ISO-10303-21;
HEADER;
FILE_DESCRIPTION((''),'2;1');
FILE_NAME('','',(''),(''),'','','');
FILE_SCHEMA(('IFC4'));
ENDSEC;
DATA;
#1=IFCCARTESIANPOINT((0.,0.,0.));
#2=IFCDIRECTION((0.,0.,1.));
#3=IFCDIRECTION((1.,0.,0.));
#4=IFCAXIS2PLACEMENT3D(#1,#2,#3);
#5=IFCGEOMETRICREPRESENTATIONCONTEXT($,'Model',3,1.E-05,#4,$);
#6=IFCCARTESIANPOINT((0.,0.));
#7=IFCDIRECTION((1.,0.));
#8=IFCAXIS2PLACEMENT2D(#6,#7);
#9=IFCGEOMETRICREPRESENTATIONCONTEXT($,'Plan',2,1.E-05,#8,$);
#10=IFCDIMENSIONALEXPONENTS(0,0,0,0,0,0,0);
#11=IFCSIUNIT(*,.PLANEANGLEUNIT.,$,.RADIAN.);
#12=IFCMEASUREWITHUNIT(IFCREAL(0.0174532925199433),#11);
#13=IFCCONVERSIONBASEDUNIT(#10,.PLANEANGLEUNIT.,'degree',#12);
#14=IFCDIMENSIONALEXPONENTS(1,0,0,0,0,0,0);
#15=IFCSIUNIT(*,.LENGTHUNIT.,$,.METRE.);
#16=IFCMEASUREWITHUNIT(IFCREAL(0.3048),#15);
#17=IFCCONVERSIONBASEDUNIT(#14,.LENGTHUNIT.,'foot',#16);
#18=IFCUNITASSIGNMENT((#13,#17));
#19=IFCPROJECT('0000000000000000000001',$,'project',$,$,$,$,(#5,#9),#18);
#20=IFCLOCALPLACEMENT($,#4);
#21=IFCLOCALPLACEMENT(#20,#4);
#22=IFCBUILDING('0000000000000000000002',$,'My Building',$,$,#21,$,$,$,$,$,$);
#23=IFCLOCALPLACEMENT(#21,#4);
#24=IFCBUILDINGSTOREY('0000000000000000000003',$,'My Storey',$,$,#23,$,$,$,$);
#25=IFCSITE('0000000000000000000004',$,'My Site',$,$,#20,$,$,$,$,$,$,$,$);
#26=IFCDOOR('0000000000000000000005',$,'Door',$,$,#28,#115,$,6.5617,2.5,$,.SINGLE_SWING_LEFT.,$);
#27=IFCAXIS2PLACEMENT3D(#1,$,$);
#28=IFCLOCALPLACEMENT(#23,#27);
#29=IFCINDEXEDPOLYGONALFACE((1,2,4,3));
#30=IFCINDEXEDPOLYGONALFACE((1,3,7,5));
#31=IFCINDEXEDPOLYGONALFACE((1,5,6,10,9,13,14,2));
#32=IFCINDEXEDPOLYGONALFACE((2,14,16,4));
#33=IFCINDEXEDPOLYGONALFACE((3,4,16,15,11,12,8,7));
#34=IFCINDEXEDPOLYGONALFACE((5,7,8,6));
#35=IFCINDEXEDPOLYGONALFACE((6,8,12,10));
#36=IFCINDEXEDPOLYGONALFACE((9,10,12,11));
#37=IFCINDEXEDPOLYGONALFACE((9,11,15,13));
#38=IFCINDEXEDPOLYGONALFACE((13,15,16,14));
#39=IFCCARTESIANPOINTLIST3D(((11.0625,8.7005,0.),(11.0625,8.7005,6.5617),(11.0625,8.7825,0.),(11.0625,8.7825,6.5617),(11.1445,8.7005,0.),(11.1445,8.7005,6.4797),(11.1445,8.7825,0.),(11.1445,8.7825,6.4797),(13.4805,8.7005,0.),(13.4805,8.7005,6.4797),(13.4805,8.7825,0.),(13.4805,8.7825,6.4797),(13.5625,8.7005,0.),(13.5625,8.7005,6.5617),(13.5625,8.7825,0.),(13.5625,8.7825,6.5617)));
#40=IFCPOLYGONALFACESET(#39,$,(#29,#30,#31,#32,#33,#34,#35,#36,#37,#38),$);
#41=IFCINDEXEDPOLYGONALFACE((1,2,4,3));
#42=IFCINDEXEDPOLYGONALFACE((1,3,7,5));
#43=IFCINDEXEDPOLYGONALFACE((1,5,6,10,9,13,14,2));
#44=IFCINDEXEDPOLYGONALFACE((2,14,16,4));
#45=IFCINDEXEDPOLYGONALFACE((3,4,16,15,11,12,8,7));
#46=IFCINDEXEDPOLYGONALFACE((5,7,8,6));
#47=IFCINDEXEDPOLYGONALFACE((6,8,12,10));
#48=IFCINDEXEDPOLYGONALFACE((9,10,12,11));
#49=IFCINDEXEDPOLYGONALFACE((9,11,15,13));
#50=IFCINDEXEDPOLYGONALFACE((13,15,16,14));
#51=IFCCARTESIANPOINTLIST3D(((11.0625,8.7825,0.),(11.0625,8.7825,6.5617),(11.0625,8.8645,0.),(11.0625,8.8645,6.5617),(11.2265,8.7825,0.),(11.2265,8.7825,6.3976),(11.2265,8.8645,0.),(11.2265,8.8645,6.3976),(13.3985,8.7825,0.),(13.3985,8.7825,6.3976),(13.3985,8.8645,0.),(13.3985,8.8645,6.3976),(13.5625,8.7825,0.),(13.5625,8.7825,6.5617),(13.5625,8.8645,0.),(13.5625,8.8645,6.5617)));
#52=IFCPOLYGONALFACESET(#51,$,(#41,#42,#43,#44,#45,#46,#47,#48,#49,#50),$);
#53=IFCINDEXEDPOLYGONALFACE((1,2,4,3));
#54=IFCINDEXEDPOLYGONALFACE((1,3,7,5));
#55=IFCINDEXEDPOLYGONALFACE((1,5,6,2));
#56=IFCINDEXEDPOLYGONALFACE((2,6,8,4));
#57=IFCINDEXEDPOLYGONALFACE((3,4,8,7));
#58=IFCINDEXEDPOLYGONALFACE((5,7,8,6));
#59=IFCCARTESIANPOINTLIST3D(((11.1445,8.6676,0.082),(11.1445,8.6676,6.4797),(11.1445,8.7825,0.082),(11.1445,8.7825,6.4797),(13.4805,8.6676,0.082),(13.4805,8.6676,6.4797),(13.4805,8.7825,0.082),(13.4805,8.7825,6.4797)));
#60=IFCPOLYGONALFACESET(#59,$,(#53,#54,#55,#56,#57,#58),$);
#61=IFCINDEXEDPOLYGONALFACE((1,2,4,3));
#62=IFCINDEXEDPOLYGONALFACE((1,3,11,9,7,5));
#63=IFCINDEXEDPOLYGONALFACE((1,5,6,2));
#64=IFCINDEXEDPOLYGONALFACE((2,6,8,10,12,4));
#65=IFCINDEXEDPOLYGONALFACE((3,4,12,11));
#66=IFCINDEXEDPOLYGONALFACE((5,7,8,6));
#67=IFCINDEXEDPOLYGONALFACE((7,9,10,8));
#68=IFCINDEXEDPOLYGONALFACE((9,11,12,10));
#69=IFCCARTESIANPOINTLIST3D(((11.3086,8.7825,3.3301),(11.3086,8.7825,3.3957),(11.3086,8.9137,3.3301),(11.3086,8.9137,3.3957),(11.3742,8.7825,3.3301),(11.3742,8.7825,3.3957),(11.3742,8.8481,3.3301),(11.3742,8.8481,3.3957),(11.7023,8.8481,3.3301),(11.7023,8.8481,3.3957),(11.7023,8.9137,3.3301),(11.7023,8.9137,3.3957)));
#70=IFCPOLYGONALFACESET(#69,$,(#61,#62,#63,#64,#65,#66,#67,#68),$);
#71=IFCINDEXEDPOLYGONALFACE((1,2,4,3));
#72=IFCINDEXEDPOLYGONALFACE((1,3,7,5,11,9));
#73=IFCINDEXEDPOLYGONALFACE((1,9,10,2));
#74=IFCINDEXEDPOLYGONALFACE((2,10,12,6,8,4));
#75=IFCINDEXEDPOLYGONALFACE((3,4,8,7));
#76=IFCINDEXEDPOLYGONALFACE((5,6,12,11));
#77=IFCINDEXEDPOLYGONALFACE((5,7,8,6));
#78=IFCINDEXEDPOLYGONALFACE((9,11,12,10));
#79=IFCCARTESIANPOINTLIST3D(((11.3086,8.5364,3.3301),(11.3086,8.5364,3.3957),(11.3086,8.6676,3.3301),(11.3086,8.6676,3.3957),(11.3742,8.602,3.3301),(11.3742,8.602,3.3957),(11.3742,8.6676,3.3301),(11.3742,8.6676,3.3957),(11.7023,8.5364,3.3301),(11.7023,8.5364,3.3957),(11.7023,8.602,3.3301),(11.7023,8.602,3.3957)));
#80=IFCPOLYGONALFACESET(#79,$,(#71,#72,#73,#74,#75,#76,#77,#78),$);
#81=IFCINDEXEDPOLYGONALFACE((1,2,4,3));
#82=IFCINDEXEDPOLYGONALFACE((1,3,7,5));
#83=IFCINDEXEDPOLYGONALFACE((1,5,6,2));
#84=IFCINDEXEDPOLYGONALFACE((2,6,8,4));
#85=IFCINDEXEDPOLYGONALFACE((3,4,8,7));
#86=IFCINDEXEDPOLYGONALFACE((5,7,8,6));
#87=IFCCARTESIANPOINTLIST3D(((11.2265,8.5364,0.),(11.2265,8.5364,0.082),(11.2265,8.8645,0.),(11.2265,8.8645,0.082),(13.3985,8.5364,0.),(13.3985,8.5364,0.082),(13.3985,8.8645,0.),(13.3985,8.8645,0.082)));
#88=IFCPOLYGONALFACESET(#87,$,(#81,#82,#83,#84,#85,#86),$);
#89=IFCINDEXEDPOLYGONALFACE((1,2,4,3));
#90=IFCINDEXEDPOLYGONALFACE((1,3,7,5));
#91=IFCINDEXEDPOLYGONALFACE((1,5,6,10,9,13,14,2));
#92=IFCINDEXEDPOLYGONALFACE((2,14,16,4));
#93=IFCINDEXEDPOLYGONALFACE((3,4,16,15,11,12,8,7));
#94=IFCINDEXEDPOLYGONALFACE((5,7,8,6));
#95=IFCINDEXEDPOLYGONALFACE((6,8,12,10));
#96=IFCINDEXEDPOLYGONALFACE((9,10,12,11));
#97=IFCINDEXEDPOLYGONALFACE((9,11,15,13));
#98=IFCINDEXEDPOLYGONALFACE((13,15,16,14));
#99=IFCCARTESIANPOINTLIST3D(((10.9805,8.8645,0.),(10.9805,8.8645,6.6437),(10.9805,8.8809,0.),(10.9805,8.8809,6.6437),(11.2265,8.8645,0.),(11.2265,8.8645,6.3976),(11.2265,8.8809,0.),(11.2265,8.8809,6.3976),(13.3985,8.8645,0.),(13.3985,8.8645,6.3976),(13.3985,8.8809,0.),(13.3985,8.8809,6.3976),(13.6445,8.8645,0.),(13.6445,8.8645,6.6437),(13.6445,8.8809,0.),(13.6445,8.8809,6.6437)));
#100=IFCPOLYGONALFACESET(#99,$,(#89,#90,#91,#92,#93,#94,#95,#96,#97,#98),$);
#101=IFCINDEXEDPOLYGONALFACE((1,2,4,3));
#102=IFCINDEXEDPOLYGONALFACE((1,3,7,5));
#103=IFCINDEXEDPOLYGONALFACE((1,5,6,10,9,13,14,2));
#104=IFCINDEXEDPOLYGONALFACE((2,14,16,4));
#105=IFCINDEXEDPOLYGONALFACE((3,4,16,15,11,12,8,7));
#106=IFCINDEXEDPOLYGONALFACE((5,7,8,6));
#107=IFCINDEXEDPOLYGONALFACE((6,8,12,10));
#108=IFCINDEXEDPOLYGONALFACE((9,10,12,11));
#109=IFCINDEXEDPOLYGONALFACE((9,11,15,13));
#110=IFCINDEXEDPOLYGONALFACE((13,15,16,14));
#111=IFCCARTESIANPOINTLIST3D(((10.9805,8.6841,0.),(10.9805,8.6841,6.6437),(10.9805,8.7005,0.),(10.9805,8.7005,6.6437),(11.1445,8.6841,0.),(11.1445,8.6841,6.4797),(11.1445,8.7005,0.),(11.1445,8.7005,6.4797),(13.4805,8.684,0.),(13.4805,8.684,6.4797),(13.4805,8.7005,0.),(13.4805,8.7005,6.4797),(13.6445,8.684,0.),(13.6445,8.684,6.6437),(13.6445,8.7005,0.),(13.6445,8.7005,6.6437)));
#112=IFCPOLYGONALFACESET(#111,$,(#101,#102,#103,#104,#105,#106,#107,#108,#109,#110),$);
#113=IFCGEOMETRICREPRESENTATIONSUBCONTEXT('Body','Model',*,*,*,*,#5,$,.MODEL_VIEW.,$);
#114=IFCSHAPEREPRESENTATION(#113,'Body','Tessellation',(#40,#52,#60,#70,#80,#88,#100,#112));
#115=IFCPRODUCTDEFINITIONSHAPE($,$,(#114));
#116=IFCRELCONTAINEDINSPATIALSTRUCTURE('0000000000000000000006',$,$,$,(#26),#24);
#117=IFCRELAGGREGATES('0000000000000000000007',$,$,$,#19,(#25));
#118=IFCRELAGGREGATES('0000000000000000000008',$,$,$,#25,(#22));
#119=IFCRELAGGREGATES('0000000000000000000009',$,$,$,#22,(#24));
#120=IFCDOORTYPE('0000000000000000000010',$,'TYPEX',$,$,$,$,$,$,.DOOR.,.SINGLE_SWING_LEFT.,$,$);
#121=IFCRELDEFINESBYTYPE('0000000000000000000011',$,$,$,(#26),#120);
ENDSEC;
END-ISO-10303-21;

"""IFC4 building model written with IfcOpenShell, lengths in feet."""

from ifc_helpers import new_model, entity, si_unit, converted_unit, frame, origin_with_axes, origin_2d_with_axis, place, context, subcontext, project, spatial, line, indexed_curve, outline, extrude, shape, source, transform, mapped, type_object, type_shapes, element, save


model = new_model("IFC4")

# Units and contexts
model_context = context("Model", 3, precision=1e-05, world=origin_with_axes())
plan_context = context("Plan", 2, precision=1e-05, world=origin_2d_with_axis())
body_context_1 = subcontext(model_context, "Body", "Model", "MODEL_VIEW")
body_context_2 = subcontext(plan_context, "Body", "Plan", "PLAN_VIEW")
ifc_project = project(units=[converted_unit("PLANEANGLEUNIT", "degree", entity("IfcReal", 0.0174532925199433), si_unit("PLANEANGLEUNIT", "RADIAN"), dimensions=[0, 0, 0, 0, 0, 0, 0]), converted_unit("LENGTHUNIT", "foot", entity("IfcReal", 0.3048), si_unit("LENGTHUNIT", "METRE"), dimensions=[1, 0, 0, 0, 0, 0, 0])], contexts=[model_context, plan_context])

# Site, building, storey
site_placement = place(None, origin_with_axes())
site = spatial("IfcSite", under=ifc_project, at=site_placement, Name="My Site")
building_placement = place(site_placement, origin_with_axes())
building = spatial("IfcBuilding", under=site, at=building_placement, Name="My Building")
storey_placement = place(building_placement, origin_with_axes())
storey = spatial("IfcBuildingStorey", under=building, at=storey_placement, Name="My Storey")

# Door
door_type = type_object("IfcDoorType", Name="TYPEX", OperationType="SINGLE_SWING_LEFT", PredefinedType="DOOR")
shared_shape_1 = source(origin_with_axes(), body_context_1, "Body", "SweptSolid", [
    extrude(outline(indexed_curve([(0.0, 0.0), (0.0, 6.5617), (2.5, 6.5617), (2.5, 0.0), (2.418, 0.0), (2.418, 6.4797), (0.082, 6.4797), (0.082, 0.0)], segments=[line(1, 2, 3, 4, 5, 6, 7, 8, 1)])), frame((0.0, 0.082, 0.0), z_axis=(0.0, -1.0, 0.0), x_axis=(1.0, 0.0, 0.0)), (0.0, 0.0, -1.0), 0.082),
    extrude(outline(indexed_curve([(0.0, 0.0), (0.0, 6.5617), (2.5, 6.5617), (2.5, 0.0), (2.336, 0.0), (2.336, 6.3976), (0.164, 6.3976), (0.164, 0.0)], segments=[line(1, 2, 3, 4, 5, 6, 7, 8, 1)])), frame((0.0, 0.0, 0.0), z_axis=(0.0, -1.0, 0.0), x_axis=(1.0, 0.0, 0.0)), (0.0, 0.0, -1.0), 0.082),
    extrude(outline(indexed_curve([(0.0, 0.0), (2.336, 0.0), (2.336, 0.1148), (0.0, 0.1148)], segments=[line(1, 2, 3, 4, 1)])), frame((0.082, 0.082, 0.082), z_axis=(0.0, 0.0, 1.0), x_axis=(1.0, 0.0, 0.0)), (0.0, 0.0, 1.0), 6.3976),
    extrude(outline(indexed_curve([(0.0, 0.0), (0.0, -0.1312), (-0.3937, -0.1312), (-0.3937, -0.0656), (-0.0656, -0.0656), (-0.0656, 0.0)], segments=[line(1, 2, 3, 4, 5, 6, 1)])), frame((2.2539, 0.082, 3.3301), z_axis=(0.0, 0.0, 1.0), x_axis=(1.0, 0.0, 0.0)), (0.0, 0.0, 1.0), 0.0656),
    extrude(outline(indexed_curve([(0.0, 0.0), (0.0, 0.1312), (-0.3937, 0.1312), (-0.3937, 0.0656), (-0.0656, 0.0656), (-0.0656, 0.0)], segments=[line(1, 2, 3, 4, 5, 6, 1)])), frame((2.2539, 0.1969, 3.3301), z_axis=(0.0, 0.0, 1.0), x_axis=(1.0, 0.0, 0.0)), (0.0, 0.0, 1.0), 0.0656),
    extrude(outline(indexed_curve([(0.0, 0.0), (2.1719, 0.0), (2.1719, 0.3281), (0.0, 0.3281)], segments=[line(1, 2, 3, 4, 1)])), frame((0.164, 0.0, 0.0), z_axis=(0.0, 0.0, 1.0), x_axis=(1.0, 0.0, 0.0)), (0.0, 0.0, 1.0), 0.082),
    extrude(outline(indexed_curve([(0.0, 0.0), (0.0, 6.6437), (2.664, 6.6437), (2.664, 0.0), (2.418, 0.0), (2.418, 6.3976), (0.2461, 6.3976), (0.2461, 0.0)], segments=[line(1, 2, 3, 4, 5, 6, 7, 8, 1)])), frame((-0.082, -0.0164, 0.0), z_axis=(0.0, -1.0, 0.0), x_axis=(1.0, 0.0, 0.0)), (0.0, 0.0, -1.0), 0.0164),
    extrude(outline(indexed_curve([(0.0, 0.0), (0.0, 6.6437), (2.664, 6.6437), (2.664, 0.0), (2.5, 0.0), (2.5, 6.4797), (0.164, 6.4797), (0.164, 0.0)], segments=[line(1, 2, 3, 4, 5, 6, 7, 8, 1)])), frame((-0.082, 0.164, 0.0), z_axis=(0.0, -1.0, 0.0), x_axis=(1.0, 0.0, 0.0)), (0.0, 0.0, -1.0), 0.0164),
])
shared_shape_2 = source(origin_with_axes(), body_context_2, "Body", "Curve2D", [
    entity("IfcIndexedPolyCurve", entity("IfcCartesianPointList2D", [[0.0, 0.0], [0.0, 0.164], [0.082, 0.164], [0.082, 0.082], [0.164, 0.082], [0.164, 0.0]]), [entity("IfcLineIndex", [1, 2, 3, 4, 5, 6, 1])]),
    entity("IfcIndexedPolyCurve", entity("IfcCartesianPointList2D", [[2.5, 0.0], [2.5, 0.164], [2.418, 0.164], [2.418, 0.082], [2.336, 0.082], [2.336, 0.0]]), [entity("IfcLineIndex", [1, 2, 3, 4, 5, 6, 1])]),
    entity("IfcTrimmedCurve", entity("IfcEllipse", entity("IfcAxis2Placement2D", entity("IfcCartesianPoint", [0.1969, 0.164]), entity("IfcDirection", [1.0, 0.0])), 2.2211, 2.336), [entity("IfcCartesianPoint", [2.418, 0.164])], [entity("IfcCartesianPoint", [0.1969, 2.5])], True, "CARTESIAN"),
    entity("IfcIndexedPolyCurve", entity("IfcCartesianPointList2D", [[0.082, 0.164], [0.1969, 0.164], [0.1969, 2.5], [0.082, 2.5]]), [entity("IfcLineIndex", [1, 2, 3, 4, 1])]),
])
type_shapes(door_type, [shared_shape_1, shared_shape_2])
placement_1 = place(storey_placement, frame((17.5208, 8.8645, 0.0), z_axis=(0.0, 0.0, 1.0), x_axis=(-1.0, 0.000001, 0.0)))
placement_2 = place(placement_1, frame((3.9583, 0.0, 0.0), z_axis=(0.0, 0.0, 1.0), x_axis=(1.0, 0.0, 0.0)))
door_placement = place(placement_2, frame((0.0, 0.0, 0.0), z_axis=(0.0, 0.0, 1.0), x_axis=(1.0, 0.0, 0.0)))
element("IfcDoor", 1, at=door_placement, inside=storey, type_object=door_type, Name="Door", OperationType="SINGLE_SWING_LEFT", OverallHeight=6.5617, OverallWidth=2.5, shapes=[
    shape(body_context_1, "Body", "MappedRepresentation", [mapped(shared_shape_1, transform((0.0, 0.0, 0.0), x_axis=(1.0, 0.0, 0.0), y_axis=(0.0, 1.0, 0.0), z_axis=(0.0, 0.0, 1.0), scale=1.0))]),
    shape(body_context_2, "Body", "MappedRepresentation", [mapped(shared_shape_2, transform((0.0, 0.0, 0.0), x_axis=(1.0, 0.0, 0.0), y_axis=(0.0, 1.0, 0.0), z_axis=(0.0, 0.0, 1.0), scale=1.0))]),
])

save(model, "model.ifc")
